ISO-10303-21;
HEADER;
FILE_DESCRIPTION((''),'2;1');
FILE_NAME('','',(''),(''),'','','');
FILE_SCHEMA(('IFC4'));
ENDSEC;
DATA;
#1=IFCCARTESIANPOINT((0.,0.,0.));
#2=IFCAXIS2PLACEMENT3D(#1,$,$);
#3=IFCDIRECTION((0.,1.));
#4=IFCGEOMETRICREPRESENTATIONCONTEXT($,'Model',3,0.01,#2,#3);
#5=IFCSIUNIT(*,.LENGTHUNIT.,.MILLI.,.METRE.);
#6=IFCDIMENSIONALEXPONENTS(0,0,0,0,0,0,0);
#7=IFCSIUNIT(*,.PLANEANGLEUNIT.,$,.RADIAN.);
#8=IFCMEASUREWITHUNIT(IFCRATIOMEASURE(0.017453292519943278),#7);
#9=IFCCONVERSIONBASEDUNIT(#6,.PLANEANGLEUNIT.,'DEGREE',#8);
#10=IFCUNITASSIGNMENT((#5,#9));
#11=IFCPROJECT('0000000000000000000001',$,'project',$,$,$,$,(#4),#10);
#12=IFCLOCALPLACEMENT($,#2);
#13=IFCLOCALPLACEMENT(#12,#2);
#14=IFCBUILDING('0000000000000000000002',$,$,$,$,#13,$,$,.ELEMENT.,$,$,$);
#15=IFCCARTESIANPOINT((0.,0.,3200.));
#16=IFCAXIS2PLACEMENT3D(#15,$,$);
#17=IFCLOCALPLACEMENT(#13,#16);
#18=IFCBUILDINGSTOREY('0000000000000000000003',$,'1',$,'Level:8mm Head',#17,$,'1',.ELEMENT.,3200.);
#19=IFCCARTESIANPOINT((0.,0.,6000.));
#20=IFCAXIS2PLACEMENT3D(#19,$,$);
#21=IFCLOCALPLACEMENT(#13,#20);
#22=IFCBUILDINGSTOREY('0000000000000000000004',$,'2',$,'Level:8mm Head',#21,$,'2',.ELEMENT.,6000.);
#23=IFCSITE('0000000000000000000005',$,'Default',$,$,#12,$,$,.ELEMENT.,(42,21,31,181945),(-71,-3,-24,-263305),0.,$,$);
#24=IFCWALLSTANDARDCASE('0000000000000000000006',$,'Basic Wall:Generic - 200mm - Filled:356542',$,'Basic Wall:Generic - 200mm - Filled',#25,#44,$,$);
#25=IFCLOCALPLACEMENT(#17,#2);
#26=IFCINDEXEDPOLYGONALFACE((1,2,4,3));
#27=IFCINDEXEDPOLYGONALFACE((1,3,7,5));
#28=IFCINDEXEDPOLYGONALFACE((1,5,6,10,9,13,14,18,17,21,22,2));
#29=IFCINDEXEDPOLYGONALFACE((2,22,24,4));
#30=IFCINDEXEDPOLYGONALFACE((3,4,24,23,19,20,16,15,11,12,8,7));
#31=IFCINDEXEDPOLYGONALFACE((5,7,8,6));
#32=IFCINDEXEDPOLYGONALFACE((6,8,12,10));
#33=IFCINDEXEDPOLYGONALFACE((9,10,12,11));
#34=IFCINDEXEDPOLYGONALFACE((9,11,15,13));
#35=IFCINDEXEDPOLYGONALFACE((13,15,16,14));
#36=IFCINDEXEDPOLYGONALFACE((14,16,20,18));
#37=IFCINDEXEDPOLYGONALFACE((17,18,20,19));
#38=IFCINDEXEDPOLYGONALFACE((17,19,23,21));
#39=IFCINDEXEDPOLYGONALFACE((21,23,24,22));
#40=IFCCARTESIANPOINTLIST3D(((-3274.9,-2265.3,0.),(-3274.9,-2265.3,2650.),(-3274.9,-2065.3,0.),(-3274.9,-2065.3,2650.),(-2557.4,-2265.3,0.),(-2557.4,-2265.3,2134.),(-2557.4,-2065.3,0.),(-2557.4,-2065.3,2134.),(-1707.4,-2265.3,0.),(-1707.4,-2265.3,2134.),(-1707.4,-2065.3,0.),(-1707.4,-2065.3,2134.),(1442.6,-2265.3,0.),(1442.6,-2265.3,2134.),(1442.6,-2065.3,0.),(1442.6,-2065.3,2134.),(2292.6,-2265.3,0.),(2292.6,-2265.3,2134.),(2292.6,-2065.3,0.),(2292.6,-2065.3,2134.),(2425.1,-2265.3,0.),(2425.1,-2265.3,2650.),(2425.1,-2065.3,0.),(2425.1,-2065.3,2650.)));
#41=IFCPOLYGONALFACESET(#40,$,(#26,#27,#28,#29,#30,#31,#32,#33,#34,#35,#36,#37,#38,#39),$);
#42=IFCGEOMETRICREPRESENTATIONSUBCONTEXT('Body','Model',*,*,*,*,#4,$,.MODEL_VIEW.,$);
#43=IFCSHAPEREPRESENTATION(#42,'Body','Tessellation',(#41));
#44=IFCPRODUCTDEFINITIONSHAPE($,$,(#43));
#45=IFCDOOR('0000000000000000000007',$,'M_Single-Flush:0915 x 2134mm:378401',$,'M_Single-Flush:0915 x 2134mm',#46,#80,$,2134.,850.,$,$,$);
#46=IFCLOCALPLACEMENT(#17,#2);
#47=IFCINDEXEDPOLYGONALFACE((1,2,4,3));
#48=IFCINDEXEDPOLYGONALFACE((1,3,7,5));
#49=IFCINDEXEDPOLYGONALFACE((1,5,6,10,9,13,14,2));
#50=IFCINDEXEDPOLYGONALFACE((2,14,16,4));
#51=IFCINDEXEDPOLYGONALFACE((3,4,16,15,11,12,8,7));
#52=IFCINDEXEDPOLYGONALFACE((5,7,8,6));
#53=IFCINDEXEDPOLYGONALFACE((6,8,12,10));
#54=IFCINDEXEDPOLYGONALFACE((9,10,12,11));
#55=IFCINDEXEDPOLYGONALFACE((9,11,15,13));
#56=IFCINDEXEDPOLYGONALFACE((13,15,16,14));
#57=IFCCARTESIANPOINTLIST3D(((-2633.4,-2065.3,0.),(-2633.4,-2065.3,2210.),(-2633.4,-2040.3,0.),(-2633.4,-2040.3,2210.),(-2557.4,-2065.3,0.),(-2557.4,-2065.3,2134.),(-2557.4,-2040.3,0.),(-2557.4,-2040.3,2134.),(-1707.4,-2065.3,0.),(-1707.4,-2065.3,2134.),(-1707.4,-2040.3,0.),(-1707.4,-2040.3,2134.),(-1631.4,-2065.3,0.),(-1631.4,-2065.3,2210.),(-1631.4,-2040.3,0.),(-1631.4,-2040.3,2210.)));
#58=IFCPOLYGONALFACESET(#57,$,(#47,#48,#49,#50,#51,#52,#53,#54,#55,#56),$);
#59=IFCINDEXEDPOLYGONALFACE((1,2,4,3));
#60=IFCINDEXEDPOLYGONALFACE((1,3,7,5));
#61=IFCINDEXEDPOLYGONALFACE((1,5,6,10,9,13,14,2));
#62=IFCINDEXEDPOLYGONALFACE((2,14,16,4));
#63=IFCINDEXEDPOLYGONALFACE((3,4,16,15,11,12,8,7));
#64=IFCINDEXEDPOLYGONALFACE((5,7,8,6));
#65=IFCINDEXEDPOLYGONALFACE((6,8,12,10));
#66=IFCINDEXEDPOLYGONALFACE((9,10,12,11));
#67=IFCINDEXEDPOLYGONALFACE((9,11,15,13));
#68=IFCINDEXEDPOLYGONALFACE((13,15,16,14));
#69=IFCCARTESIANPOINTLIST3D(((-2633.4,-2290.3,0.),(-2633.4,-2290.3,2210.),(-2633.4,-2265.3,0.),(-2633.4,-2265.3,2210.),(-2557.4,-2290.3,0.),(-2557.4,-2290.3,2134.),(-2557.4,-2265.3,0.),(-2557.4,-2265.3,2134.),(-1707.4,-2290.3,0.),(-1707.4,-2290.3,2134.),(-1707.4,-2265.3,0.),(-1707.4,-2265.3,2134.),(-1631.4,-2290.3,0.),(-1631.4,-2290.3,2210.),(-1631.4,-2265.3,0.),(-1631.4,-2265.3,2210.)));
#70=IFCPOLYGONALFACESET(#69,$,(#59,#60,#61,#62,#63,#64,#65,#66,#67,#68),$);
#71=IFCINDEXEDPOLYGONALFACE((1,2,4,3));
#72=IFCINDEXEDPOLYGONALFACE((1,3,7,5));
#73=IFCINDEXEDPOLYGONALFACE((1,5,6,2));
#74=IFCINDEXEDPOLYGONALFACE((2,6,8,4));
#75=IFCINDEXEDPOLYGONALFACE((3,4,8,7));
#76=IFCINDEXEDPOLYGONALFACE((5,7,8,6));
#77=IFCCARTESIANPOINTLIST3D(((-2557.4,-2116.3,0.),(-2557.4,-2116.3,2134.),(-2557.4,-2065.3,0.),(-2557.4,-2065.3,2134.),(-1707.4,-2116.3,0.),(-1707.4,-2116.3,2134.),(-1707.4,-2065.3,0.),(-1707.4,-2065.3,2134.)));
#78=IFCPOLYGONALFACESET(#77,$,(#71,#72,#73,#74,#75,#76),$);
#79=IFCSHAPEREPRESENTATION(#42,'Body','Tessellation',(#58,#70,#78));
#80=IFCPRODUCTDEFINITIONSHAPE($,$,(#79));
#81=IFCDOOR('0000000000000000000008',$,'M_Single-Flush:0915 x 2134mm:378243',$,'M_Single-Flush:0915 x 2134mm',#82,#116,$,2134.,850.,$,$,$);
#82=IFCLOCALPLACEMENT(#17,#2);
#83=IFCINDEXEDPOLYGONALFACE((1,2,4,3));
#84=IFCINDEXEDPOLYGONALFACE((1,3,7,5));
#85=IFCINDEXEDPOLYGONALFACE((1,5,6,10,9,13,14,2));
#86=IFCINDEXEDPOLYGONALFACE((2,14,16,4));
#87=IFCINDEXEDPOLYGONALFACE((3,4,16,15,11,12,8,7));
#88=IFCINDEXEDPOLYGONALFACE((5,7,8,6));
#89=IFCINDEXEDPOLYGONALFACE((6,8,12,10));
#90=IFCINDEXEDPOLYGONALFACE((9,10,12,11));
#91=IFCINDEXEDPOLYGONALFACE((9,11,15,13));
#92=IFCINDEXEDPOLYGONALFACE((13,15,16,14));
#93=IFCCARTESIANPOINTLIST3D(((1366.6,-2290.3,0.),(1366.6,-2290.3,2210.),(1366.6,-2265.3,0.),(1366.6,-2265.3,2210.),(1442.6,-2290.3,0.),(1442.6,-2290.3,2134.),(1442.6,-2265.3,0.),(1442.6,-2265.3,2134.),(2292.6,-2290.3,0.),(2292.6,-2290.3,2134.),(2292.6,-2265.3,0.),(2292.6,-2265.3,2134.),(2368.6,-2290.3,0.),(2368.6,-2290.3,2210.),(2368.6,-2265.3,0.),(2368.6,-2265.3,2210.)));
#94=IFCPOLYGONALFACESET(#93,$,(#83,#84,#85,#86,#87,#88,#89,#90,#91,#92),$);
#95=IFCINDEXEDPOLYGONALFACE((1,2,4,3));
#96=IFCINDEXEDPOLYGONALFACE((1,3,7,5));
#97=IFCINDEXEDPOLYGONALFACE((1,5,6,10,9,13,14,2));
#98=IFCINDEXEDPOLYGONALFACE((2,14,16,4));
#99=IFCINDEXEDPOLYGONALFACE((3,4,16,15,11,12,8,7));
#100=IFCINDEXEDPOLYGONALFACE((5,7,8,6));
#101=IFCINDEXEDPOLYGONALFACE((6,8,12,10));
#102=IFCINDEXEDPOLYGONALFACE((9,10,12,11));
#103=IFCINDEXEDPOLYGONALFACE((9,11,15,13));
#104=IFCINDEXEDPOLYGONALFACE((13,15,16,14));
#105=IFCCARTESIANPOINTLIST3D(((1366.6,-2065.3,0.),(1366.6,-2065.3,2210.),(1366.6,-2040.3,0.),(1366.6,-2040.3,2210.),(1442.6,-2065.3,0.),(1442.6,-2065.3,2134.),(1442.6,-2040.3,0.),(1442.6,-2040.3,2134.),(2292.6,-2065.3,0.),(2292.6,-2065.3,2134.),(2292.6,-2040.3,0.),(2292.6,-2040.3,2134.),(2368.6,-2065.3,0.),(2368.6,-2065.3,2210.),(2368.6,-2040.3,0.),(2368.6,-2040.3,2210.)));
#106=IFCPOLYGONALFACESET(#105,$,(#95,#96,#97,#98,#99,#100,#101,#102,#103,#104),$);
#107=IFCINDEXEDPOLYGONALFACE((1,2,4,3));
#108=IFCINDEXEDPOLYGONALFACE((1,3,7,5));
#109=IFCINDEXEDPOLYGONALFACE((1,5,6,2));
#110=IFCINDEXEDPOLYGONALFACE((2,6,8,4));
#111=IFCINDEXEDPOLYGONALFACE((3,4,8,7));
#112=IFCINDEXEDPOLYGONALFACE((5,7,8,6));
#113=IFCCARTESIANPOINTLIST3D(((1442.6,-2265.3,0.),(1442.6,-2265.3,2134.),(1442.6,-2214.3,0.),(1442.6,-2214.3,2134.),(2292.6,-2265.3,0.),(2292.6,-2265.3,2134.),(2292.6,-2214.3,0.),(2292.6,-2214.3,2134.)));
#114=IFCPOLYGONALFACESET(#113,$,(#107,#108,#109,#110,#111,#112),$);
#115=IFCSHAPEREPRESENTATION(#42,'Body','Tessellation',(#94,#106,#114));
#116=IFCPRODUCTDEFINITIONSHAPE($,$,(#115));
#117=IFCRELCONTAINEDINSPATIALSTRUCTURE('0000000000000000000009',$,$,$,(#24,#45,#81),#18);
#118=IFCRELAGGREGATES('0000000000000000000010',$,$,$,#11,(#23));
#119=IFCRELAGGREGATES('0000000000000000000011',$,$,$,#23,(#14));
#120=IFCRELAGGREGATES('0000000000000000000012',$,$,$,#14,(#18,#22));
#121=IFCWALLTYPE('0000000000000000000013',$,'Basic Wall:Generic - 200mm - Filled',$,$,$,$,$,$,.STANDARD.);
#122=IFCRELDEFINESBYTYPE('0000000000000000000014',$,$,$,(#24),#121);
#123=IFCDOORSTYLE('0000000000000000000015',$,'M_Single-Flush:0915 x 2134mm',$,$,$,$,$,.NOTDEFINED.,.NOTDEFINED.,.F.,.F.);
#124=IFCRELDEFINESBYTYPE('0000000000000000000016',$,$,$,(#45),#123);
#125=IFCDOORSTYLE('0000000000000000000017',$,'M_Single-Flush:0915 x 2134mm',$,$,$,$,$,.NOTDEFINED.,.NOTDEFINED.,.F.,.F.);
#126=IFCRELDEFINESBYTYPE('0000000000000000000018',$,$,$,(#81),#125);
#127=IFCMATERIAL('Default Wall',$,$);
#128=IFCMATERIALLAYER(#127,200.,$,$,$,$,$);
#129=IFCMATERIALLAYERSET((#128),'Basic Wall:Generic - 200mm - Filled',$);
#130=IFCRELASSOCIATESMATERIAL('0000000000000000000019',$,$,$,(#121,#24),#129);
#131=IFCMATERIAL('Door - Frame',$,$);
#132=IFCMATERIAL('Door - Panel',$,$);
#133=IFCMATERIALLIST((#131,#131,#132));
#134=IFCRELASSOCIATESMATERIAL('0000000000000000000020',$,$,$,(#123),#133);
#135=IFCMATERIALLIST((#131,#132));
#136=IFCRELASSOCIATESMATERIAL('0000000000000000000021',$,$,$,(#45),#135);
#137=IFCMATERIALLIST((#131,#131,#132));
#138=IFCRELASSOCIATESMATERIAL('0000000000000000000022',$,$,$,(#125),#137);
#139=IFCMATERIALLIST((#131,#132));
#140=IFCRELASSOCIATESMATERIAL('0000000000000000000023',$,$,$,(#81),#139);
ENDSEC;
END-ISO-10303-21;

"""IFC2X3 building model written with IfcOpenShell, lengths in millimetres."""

from ifc_helpers import new_model, entity, si_unit, converted_unit, direction, frame, frame_2d, origin, place, context, subcontext, project, spatial, polyline, rectangle, outline, extrude, clip, bounded_halfspace, source, transform, mapped, material, material_list, layer, layer_set, layer_usage, type_object, type_shapes, element, fill, save


model = new_model("IFC2X3")

# Units and contexts
model_context = context("Model", 3, precision=0.01, world=origin(), true_north=direction((0.0, 1.0)))
body_context = subcontext(model_context, "Body", "Model", "MODEL_VIEW")
ifc_project = project(units=[si_unit("LENGTHUNIT", "METRE", prefix="MILLI"), converted_unit("PLANEANGLEUNIT", "DEGREE", entity("IfcRatioMeasure", 0.017453292519943278), si_unit("PLANEANGLEUNIT", "RADIAN"), dimensions=[0, 0, 0, 0, 0, 0, 0])], contexts=[model_context])

# Site, building, storey
site_placement = place(None, origin())
site = spatial("IfcSite", under=ifc_project, at=site_placement, Name="Default", CompositionType="ELEMENT", RefLatitude=(42, 21, 31, 181945), RefLongitude=(-71, -3, -24, -263305), RefElevation=0.0)
building_placement = place(site_placement, origin())
building = spatial("IfcBuilding", under=site, at=building_placement, CompositionType="ELEMENT")
storey_1_placement = place(building_placement, frame((0.0, 0.0, 3200.0)))
storey_1 = spatial("IfcBuildingStorey", under=building, at=storey_1_placement, Name="1", ObjectType="Level:8mm Head", LongName="1", CompositionType="ELEMENT", Elevation=3200.0)

# Shared definitions
ifc_material_1 = material(Name="Default Wall")

# Shared definitions
storey_2_placement = place(building_placement, frame((0.0, 0.0, 6000.0)))
storey_2 = spatial("IfcBuildingStorey", under=building, at=storey_2_placement, Name="2", ObjectType="Level:8mm Head", LongName="2", CompositionType="ELEMENT", Elevation=6000.0)

# Shared definitions
ifc_layer_1 = layer(ifc_material_1, 200.0)
ifc_layer_set_1 = layer_set([ifc_layer_1], Name="Basic Wall:Generic - 200mm - Filled")
wall_type_1 = type_object("IfcWallType", Name="Basic Wall:Generic - 200mm - Filled", PredefinedType="STANDARD", material=ifc_layer_set_1)

# Wall, openings, doors
ifc_layer_usage_1 = layer_usage(ifc_layer_set_1, "AXIS2", "NEGATIVE", 100.0)
wall_1_placement = place(storey_1_placement, frame((2425.1, -2165.3, 0.0), z_axis=(0.0, 0.0, 1.0), x_axis=(-1.0, 0.0, 0.0)))
wall_1 = element("IfcWallStandardCase", 1, at=wall_1_placement, inside=storey_1, type_object=wall_type_1, material=ifc_layer_usage_1, Name="Basic Wall:Generic - 200mm - Filled:356542", ObjectType="Basic Wall:Generic - 200mm - Filled", context=body_context, shape_type="Clipping", body=[
    clip(extrude(rectangle(XDim=5700.0, YDim=200.0, at=frame_2d((2850.0, 0.0), x_axis=(1.0, 0.0))), origin(), (0.0, 0.0, 1.0), 2650.0), bounded_halfspace(frame((0.0, -100.0, 2650.0), z_axis=(0.0, 0.0, -1.0), x_axis=(0.0, 1.0, 0.0)), True, frame((0.0, -100.0, 2650.0)), polyline([(0.0, 0.0), (1737360.0, 0.0), (1737360.0, 60960.0), (1036320.0, 60960.0), (975360.0, 60960.0), (365760.0, 60960.0), (335280.0, 60960.0), (0.0, 60960.0), (0.0, 0.0)]))),
])
opening_1_placement = place(wall_1_placement, frame((132.5, -100.0, 0.0)))
opening_1 = element("IfcOpeningElement", 2, at=opening_1_placement, cuts=wall_1, ObjectType="Opening", context=body_context, shape_type="SweptSolid", body=[
    extrude(rectangle(XDim=850.0, YDim=2134.0, at=frame_2d((1067.0, 425.0), x_axis=(0.0, 1.0))), frame((0.0, 0.0, 0.0), z_axis=(0.0, 1.0, 0.0), x_axis=(0.0, 0.0, 1.0)), (0.0, 0.0, 1.0), 200.0),
])
opening_2_placement = place(wall_1_placement, frame((4982.5, 100.0, 0.0)))
opening_2 = element("IfcOpeningElement", 3, at=opening_2_placement, cuts=wall_1, ObjectType="Opening", context=body_context, shape_type="SweptSolid", body=[
    extrude(rectangle(XDim=850.0, YDim=2134.0, at=frame_2d((1067.0, 425.0), x_axis=(0.0, -1.0))), frame((0.0, 0.0, 0.0), z_axis=(0.0, -1.0, 0.0), x_axis=(0.0, 0.0, 1.0)), (0.0, 0.0, 1.0), 200.0),
])
ifc_material_2 = material(Name="Door - Frame")
ifc_material_3 = material(Name="Door - Panel")
ifc_material_list_1 = material_list([ifc_material_2, ifc_material_3])
ifc_material_list_2 = material_list([ifc_material_2, ifc_material_2, ifc_material_3])
door_style_1 = type_object("IfcDoorStyle", Name="M_Single-Flush:0915 x 2134mm", ConstructionType="NOTDEFINED", OperationType="NOTDEFINED", ParameterTakesPrecedence=False, Sizeable=False, material=ifc_material_list_2)
shared_shape_1 = source(origin(), body_context, "Body", "SweptSolid", [
    extrude(outline(polyline([(-501.0, -1124.0), (501.0, -1124.0), (501.0, 1086.0), (425.0, 1086.0), (425.0, -1048.0), (-425.0, -1048.0), (-425.0, 1086.0), (-501.0, 1086.0), (-501.0, -1124.0)])), frame((425.0, 225.0, 1086.0), z_axis=(0.0, -1.0, 0.0), x_axis=(-1.0, 0.0, 0.0)), (0.0, 0.0, 1.0), 25.0),
    extrude(outline(polyline([(-1124.0, -501.0), (1086.0, -501.0), (1086.0, -425.0), (-1048.0, -425.0), (-1048.0, 425.0), (1086.0, 425.0), (1086.0, 501.0), (-1124.0, 501.0), (-1124.0, -501.0)])), frame((425.0, 0.0, 1086.0), z_axis=(0.0, -1.0, 0.0), x_axis=(0.0, 0.0, -1.0)), (0.0, 0.0, 1.0), 25.0),
    extrude(rectangle(XDim=850.0, YDim=51.0, at=frame_2d((0.0, 0.0), x_axis=(1.0, 0.0))), frame((425.0, 174.5, 0.0)), (0.0, 0.0, 1.0), 2134.0),
])
type_shapes(door_style_1, [shared_shape_1])
door_1_placement = place(opening_2_placement, frame((0.0, 0.0, 0.0), z_axis=(0.0, 0.0, 1.0), x_axis=(-1.0, 0.0, 0.0)))
door_1 = element("IfcDoor", 4, at=door_1_placement, inside=storey_1, type_object=door_style_1, material=ifc_material_list_1, Name="M_Single-Flush:0915 x 2134mm:378401", ObjectType="M_Single-Flush:0915 x 2134mm", OverallHeight=2134.0, OverallWidth=850.0, context=body_context, shape_type="MappedRepresentation", body=[
    mapped(shared_shape_1, transform((0.0, 0.0, 0.0), scale=1.0)),
])
fill(opening_2, door_1)
ifc_material_list_3 = material_list([ifc_material_2, ifc_material_3])
ifc_material_list_4 = material_list([ifc_material_2, ifc_material_2, ifc_material_3])
door_style_2 = type_object("IfcDoorStyle", Name="M_Single-Flush:0915 x 2134mm", ConstructionType="NOTDEFINED", OperationType="NOTDEFINED", ParameterTakesPrecedence=False, Sizeable=False, material=ifc_material_list_4)
shared_shape_2 = source(origin(), body_context, "Body", "SweptSolid", [
    extrude(outline(polyline([(-501.0, -1124.0), (501.0, -1124.0), (501.0, 1086.0), (425.0, 1086.0), (425.0, -1048.0), (-425.0, -1048.0), (-425.0, 1086.0), (-501.0, 1086.0), (-501.0, -1124.0)])), frame((425.0, 200.0, 1086.0), z_axis=(0.0, 1.0, 0.0), x_axis=(1.0, 0.0, 0.0)), (0.0, 0.0, 1.0), 25.0),
    extrude(outline(polyline([(-1124.0, -501.0), (1086.0, -501.0), (1086.0, -425.0), (-1048.0, -425.0), (-1048.0, 425.0), (1086.0, 425.0), (1086.0, 501.0), (-1124.0, 501.0), (-1124.0, -501.0)])), frame((425.0, -25.0, 1086.0), z_axis=(0.0, 1.0, 0.0), x_axis=(0.0, 0.0, -1.0)), (0.0, 0.0, 1.0), 25.0),
    extrude(rectangle(XDim=51.0, YDim=850.0, at=frame_2d((0.0, 0.0), x_axis=(1.0, 0.0))), frame((425.0, 174.5, 0.0), z_axis=(0.0, 0.0, 1.0), x_axis=(0.0, 1.0, 0.0)), (0.0, 0.0, 1.0), 2134.0),
])
type_shapes(door_style_2, [shared_shape_2])
door_2_placement = place(opening_1_placement, origin())
door_2 = element("IfcDoor", 5, at=door_2_placement, inside=storey_1, type_object=door_style_2, material=ifc_material_list_3, Name="M_Single-Flush:0915 x 2134mm:378243", ObjectType="M_Single-Flush:0915 x 2134mm", OverallHeight=2134.0, OverallWidth=850.0, context=body_context, shape_type="MappedRepresentation", body=[
    mapped(shared_shape_2, transform((0.0, 0.0, 0.0), scale=1.0)),
])
fill(opening_1, door_2)

save(model, "model.ifc")
